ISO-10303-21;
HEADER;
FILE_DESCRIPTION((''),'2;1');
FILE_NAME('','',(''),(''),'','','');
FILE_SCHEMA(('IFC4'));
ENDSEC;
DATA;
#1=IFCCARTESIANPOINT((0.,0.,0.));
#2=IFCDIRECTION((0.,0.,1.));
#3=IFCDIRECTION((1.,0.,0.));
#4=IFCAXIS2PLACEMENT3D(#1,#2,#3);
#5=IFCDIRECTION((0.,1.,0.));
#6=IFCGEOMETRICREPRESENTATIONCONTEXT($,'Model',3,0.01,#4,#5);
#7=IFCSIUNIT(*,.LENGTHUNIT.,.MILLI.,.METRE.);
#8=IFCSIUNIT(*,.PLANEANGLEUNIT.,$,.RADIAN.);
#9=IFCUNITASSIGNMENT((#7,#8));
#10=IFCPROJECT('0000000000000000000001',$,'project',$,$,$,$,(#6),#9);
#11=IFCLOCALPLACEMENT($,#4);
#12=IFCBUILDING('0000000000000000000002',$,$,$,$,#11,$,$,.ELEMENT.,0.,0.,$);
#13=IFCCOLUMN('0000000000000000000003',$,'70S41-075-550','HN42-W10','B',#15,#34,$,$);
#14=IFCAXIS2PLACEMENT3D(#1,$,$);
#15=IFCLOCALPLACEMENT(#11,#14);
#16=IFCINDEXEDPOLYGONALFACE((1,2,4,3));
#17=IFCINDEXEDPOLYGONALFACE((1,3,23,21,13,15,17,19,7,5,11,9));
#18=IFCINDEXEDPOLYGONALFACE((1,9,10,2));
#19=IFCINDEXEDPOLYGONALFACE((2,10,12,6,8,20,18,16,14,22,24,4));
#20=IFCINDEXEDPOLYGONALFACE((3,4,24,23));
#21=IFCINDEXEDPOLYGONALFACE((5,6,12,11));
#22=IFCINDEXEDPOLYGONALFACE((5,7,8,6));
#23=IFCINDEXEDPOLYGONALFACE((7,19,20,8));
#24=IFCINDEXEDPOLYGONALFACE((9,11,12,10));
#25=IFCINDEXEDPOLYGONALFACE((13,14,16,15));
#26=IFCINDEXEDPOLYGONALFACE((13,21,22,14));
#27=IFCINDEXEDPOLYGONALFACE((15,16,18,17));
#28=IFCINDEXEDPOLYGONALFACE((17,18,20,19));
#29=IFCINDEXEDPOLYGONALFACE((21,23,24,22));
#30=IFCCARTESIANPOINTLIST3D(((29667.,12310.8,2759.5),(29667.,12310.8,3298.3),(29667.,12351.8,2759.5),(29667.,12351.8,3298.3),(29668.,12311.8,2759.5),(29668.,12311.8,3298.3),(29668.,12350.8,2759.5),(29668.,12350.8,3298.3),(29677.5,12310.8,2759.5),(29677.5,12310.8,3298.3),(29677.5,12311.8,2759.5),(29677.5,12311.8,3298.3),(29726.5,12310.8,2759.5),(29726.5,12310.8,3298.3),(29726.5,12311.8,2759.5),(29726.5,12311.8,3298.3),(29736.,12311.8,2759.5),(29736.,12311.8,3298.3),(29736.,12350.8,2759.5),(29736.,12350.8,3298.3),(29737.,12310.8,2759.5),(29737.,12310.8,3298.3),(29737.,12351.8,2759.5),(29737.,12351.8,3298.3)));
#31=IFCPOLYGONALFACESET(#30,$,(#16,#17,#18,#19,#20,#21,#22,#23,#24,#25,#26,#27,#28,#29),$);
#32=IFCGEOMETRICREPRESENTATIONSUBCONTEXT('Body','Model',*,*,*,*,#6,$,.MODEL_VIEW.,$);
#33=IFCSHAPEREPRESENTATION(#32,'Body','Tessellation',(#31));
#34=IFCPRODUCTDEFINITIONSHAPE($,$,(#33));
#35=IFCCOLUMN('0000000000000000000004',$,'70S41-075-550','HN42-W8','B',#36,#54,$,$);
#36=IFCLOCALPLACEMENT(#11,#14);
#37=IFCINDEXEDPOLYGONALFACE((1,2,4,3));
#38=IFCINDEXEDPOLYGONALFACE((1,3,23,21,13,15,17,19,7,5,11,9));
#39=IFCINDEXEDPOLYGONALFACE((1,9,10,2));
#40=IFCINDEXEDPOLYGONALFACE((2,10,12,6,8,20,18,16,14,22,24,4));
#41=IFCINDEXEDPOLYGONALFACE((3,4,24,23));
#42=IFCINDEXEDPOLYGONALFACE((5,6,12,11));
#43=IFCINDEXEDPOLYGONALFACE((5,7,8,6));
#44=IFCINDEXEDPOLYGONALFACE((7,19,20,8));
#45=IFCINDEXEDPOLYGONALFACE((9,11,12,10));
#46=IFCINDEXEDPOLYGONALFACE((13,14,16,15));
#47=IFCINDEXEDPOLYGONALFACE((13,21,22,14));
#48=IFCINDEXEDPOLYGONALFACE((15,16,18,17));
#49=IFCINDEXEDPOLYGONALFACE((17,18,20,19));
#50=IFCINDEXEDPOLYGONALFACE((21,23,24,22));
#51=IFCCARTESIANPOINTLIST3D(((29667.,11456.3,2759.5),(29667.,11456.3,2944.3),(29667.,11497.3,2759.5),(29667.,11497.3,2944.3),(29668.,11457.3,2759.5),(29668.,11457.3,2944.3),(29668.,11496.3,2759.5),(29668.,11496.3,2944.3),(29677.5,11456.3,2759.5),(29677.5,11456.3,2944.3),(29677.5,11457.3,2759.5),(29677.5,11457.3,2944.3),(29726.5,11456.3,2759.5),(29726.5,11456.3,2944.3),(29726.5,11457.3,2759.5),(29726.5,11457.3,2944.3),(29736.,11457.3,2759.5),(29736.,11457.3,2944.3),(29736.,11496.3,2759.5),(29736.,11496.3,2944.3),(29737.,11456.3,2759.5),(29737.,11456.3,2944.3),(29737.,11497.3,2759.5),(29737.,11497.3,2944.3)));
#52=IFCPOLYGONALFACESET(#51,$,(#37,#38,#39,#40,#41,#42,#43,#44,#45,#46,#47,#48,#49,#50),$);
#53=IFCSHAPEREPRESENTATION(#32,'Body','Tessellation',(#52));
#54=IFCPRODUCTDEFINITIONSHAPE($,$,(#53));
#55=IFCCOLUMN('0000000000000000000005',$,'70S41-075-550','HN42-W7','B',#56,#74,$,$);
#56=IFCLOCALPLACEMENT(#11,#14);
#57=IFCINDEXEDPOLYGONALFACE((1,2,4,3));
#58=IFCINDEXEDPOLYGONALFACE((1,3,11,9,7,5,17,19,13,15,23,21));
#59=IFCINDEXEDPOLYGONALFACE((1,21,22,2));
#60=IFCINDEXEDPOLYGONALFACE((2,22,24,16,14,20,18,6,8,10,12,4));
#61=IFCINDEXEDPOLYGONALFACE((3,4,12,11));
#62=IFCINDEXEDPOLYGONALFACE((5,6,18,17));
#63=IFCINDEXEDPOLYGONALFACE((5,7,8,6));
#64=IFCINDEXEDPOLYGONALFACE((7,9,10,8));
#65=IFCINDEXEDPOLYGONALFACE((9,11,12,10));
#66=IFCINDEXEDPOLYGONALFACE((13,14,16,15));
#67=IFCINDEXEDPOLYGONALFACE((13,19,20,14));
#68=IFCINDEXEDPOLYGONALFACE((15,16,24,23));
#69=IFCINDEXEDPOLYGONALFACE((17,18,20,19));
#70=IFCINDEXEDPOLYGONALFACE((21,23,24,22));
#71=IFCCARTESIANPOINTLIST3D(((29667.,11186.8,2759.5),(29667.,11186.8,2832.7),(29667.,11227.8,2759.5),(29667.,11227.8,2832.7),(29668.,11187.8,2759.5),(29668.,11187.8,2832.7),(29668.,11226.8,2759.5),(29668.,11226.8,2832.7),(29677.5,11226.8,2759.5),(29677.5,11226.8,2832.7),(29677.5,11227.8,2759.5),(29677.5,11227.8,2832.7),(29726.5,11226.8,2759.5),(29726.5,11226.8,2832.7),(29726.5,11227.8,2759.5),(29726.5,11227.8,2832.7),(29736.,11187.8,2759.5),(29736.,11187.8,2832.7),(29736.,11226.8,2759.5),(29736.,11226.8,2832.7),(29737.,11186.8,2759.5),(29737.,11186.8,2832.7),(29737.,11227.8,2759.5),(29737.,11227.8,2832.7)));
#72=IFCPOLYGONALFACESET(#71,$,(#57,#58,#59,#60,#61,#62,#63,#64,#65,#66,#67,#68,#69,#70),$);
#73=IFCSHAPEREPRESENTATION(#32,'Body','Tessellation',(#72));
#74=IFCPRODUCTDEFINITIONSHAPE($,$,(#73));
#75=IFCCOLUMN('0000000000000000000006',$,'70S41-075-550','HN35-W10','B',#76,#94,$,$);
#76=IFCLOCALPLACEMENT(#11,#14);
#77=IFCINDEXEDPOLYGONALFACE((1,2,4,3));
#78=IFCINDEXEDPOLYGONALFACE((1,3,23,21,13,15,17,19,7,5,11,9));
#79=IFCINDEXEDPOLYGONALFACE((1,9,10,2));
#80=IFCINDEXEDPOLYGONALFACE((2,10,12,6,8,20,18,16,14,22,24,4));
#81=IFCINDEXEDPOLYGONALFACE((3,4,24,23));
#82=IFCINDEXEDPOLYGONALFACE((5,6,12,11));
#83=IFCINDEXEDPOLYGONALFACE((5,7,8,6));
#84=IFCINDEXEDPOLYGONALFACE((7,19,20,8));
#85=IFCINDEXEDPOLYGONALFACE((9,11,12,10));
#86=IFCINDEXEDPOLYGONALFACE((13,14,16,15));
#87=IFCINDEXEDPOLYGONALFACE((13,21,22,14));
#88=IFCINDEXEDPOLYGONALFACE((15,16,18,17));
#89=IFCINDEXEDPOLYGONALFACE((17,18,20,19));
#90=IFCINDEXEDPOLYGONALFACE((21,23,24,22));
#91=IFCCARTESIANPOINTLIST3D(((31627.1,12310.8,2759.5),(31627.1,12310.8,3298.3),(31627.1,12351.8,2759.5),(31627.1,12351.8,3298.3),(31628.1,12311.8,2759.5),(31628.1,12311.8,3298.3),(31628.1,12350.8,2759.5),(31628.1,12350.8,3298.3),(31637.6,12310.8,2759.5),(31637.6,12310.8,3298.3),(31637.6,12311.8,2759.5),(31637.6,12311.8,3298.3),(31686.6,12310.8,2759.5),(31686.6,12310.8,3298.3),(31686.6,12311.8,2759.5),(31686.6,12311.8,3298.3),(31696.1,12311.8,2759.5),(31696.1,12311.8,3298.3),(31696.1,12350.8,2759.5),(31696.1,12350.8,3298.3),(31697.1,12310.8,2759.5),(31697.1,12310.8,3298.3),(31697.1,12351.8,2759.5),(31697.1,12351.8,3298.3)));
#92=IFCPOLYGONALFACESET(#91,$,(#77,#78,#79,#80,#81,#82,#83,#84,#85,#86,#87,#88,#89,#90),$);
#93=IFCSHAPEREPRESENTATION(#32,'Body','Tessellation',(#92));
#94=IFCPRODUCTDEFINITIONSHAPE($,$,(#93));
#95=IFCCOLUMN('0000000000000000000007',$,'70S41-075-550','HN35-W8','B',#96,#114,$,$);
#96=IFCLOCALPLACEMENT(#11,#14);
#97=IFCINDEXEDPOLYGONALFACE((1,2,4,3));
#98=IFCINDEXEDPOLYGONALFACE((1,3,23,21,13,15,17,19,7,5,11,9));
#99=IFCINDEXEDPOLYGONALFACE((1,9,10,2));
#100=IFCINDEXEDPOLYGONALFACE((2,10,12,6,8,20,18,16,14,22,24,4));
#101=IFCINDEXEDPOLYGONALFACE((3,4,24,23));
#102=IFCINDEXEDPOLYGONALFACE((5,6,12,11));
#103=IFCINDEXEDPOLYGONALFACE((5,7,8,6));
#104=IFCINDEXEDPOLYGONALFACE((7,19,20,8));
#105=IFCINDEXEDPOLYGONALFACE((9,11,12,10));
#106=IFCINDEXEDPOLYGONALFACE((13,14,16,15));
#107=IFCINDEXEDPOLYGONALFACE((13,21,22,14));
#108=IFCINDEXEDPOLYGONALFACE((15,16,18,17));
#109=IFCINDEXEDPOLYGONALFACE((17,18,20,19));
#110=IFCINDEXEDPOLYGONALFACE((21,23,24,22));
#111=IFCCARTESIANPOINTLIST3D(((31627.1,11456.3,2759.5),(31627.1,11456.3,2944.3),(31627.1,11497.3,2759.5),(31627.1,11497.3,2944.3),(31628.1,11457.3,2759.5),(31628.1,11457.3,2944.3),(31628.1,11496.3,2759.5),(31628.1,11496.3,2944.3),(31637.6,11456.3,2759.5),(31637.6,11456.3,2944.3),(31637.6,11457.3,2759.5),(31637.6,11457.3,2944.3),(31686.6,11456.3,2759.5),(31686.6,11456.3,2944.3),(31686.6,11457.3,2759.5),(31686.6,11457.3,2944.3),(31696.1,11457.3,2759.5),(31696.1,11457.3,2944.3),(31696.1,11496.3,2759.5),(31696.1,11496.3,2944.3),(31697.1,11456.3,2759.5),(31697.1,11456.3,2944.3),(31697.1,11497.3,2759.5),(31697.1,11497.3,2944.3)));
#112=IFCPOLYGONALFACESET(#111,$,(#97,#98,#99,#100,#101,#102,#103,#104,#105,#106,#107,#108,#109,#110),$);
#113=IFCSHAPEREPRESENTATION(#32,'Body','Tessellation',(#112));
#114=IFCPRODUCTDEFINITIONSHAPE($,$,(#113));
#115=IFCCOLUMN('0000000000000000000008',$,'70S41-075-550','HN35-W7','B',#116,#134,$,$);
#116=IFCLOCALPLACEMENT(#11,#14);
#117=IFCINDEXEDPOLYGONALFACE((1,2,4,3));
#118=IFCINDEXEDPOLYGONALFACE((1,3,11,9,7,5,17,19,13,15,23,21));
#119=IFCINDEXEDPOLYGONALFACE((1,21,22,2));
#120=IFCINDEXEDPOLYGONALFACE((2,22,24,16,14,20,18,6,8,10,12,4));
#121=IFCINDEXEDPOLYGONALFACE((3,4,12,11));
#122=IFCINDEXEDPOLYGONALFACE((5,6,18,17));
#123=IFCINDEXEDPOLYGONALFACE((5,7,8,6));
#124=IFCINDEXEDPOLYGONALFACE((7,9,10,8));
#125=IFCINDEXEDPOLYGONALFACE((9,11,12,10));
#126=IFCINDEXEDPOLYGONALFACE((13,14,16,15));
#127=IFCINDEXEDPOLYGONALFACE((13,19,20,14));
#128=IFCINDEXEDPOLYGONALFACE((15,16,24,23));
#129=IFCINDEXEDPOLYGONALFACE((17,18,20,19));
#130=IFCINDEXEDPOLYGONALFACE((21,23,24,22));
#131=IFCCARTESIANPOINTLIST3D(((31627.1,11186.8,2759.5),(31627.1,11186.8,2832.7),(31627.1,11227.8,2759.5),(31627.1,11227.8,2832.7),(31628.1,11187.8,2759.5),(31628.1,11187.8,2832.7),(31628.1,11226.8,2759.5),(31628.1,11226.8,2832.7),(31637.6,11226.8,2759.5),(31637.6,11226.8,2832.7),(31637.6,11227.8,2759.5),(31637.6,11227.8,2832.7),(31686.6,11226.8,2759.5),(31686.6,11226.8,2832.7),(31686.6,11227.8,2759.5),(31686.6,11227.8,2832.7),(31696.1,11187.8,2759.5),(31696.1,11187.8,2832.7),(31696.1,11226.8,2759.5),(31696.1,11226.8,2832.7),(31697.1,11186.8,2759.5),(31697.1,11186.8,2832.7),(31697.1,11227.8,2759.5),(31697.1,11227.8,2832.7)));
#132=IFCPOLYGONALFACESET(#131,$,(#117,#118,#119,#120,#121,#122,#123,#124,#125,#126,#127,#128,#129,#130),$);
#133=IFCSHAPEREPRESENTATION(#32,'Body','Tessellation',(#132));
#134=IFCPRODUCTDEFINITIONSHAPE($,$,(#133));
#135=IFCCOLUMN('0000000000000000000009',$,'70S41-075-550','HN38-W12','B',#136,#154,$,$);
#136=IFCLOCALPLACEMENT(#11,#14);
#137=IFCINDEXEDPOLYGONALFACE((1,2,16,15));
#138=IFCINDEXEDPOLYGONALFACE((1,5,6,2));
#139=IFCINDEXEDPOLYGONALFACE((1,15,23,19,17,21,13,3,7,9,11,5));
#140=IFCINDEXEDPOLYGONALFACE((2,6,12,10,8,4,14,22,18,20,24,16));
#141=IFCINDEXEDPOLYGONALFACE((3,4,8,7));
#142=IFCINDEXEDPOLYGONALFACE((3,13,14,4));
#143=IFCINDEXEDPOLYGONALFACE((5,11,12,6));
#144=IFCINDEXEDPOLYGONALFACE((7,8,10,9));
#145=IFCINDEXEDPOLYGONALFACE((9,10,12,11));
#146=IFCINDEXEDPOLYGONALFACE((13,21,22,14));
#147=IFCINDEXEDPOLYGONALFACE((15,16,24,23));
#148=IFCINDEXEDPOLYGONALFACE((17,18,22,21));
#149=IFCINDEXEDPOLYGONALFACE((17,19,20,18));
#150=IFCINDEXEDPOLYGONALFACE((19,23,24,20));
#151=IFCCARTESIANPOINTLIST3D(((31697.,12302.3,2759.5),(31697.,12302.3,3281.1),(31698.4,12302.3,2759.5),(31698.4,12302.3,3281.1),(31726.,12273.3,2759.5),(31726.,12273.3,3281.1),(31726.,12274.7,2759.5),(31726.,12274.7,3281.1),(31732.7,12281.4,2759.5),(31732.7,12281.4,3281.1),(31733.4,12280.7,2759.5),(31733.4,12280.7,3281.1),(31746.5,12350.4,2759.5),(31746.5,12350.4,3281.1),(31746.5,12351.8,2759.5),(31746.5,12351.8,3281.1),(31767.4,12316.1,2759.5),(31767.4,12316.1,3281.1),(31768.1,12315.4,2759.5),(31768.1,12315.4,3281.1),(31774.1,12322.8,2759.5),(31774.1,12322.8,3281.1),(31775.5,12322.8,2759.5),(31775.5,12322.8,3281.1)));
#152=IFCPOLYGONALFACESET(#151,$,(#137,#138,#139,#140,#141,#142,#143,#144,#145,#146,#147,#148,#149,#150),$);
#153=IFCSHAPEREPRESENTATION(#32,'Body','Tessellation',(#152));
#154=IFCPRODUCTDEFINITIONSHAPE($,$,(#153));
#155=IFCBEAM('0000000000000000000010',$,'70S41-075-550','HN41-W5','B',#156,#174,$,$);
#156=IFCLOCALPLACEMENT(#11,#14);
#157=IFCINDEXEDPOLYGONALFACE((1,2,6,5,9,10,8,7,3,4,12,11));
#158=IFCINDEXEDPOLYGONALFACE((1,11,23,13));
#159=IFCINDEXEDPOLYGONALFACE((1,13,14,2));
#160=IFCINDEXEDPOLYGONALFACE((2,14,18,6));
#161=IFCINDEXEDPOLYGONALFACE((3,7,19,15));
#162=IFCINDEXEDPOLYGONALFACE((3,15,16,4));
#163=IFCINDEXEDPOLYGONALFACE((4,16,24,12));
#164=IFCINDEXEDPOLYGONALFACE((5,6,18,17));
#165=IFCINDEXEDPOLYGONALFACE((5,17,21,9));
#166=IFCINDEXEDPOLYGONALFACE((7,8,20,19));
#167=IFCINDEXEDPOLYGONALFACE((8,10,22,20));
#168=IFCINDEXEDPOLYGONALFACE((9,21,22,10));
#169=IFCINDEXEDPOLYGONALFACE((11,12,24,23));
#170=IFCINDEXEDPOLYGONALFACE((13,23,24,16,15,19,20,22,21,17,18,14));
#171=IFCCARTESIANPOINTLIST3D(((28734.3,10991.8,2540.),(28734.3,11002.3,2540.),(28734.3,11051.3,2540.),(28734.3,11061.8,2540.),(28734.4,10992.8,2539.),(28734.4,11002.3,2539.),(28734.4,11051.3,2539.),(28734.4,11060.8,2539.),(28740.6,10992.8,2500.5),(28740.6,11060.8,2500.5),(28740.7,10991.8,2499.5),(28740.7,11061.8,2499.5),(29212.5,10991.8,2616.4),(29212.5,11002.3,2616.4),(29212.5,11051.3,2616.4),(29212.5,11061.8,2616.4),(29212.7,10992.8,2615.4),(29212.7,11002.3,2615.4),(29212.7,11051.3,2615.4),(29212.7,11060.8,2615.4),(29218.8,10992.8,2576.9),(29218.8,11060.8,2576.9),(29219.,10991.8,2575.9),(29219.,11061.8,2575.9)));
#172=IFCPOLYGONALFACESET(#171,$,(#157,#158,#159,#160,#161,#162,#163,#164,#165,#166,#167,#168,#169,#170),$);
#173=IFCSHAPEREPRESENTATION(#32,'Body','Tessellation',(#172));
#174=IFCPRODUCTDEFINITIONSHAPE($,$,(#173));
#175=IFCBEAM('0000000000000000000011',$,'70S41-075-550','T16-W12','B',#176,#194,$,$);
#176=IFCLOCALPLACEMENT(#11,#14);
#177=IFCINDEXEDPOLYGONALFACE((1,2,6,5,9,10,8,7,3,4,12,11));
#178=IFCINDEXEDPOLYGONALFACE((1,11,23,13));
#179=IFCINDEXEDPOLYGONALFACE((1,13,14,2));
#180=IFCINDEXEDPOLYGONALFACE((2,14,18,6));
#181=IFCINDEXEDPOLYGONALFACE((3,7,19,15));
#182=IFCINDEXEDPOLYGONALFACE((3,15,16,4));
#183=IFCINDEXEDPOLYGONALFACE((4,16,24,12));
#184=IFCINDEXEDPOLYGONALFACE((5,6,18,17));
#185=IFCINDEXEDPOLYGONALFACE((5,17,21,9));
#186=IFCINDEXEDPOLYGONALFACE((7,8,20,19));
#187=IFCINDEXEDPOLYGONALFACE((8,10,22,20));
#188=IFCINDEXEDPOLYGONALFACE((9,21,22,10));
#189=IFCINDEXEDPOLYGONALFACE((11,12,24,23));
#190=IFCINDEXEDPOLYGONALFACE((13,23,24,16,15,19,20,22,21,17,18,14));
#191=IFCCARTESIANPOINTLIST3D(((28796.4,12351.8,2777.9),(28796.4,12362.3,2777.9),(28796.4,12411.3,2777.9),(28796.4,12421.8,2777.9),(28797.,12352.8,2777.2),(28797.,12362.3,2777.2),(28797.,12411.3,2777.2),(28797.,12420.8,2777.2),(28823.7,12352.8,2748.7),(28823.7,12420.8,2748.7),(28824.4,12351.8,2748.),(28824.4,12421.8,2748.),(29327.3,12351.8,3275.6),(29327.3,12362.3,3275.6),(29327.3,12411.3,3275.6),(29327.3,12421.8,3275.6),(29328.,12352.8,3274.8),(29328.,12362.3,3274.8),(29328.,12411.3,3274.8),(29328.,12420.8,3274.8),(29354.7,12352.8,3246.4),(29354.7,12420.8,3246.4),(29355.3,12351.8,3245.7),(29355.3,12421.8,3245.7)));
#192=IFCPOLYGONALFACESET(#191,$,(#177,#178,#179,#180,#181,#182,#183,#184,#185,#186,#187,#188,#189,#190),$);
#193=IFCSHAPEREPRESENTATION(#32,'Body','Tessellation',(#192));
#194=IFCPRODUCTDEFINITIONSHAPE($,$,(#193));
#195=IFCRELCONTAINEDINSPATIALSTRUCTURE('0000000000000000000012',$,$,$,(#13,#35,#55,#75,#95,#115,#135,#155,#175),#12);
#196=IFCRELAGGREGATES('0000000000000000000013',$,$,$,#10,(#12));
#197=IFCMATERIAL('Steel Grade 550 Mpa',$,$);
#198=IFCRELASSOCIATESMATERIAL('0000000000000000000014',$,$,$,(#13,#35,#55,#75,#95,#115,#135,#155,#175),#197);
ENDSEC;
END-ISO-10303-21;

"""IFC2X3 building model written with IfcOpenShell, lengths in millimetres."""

from ifc_helpers import new_model, si_unit, direction, frame, origin, origin_with_axes, origin_2d_with_axis, place, context, subcontext, project, spatial, c_section, extrude, source, transform, mapped, material, element, save


model = new_model("IFC2X3")

# Units and contexts
model_context = context("Model", 3, precision=0.01, world=origin_with_axes(), true_north=direction((0.0, 1.0, 0.0)))
body_context = subcontext(model_context, "Body", "Model", "MODEL_VIEW")
ifc_project = project(units=[si_unit("LENGTHUNIT", "METRE", prefix="MILLI"), si_unit("PLANEANGLEUNIT", "RADIAN")], contexts=[model_context])

# Building
building_placement = place(None, origin_with_axes())
building = spatial("IfcBuilding", under=ifc_project, at=building_placement, CompositionType="ELEMENT", ElevationOfRefHeight=0.0, ElevationOfTerrain=0.0)

# Columns
ifc_material = material(Name="Steel Grade 550 Mpa")
shared_shape_1 = source(origin(), body_context, "Body", "SweptSolid", [
    extrude(c_section(Depth=70.0, Width=41.0, WallThickness=1.0, Girth=10.5, at=origin_2d_with_axis()), origin_with_axes(), (0.0, 0.0, 1.0), 538.8),
])
column_1_placement = place(None, frame((29702.0, 12331.3, 2759.5), z_axis=(0.0, 0.0, 1.0), x_axis=(0.0, -1.0, 0.0)))
element("IfcColumn", 1, at=column_1_placement, inside=building, material=ifc_material, Name="70S41-075-550", Description="HN42-W10", ObjectType="B", context=body_context, shape_type="MappedRepresentation", body=[
    mapped(shared_shape_1, transform((0.0, 0.0, 0.0), scale=1.0)),
])
shared_shape_2 = source(origin(), body_context, "Body", "SweptSolid", [
    extrude(c_section(Depth=70.0, Width=41.0, WallThickness=1.0, Girth=10.5, at=origin_2d_with_axis()), origin_with_axes(), (0.0, 0.0, 1.0), 184.8),
])
column_2_placement = place(None, frame((29702.0, 11476.8, 2759.5), z_axis=(0.0, 0.0, 1.0), x_axis=(0.0, -1.0, 0.0)))
element("IfcColumn", 2, at=column_2_placement, inside=building, material=ifc_material, Name="70S41-075-550", Description="HN42-W8", ObjectType="B", context=body_context, shape_type="MappedRepresentation", body=[
    mapped(shared_shape_2, transform((0.0, 0.0, 0.0), scale=1.0)),
])
shared_shape_3 = source(origin(), body_context, "Body", "SweptSolid", [
    extrude(c_section(Depth=70.0, Width=41.0, WallThickness=1.0, Girth=10.5, at=origin_2d_with_axis()), origin_with_axes(), (0.0, 0.0, 1.0), 73.2),
])
column_3_placement = place(None, frame((29702.0, 11207.3, 2832.7), z_axis=(0.0, 0.0, -1.0), x_axis=(0.0, 1.0, 0.0)))
element("IfcColumn", 3, at=column_3_placement, inside=building, material=ifc_material, Name="70S41-075-550", Description="HN42-W7", ObjectType="B", context=body_context, shape_type="MappedRepresentation", body=[
    mapped(shared_shape_3, transform((0.0, 0.0, 0.0), scale=1.0)),
])
shared_shape_4 = source(origin(), body_context, "Body", "SweptSolid", [
    extrude(c_section(Depth=70.0, Width=41.0, WallThickness=1.0, Girth=10.5, at=origin_2d_with_axis()), origin_with_axes(), (0.0, 0.0, 1.0), 538.8),
])
column_4_placement = place(None, frame((31662.1, 12331.3, 2759.5), z_axis=(0.0, 0.0, 1.0), x_axis=(0.0, -1.0, 0.0)))
element("IfcColumn", 4, at=column_4_placement, inside=building, material=ifc_material, Name="70S41-075-550", Description="HN35-W10", ObjectType="B", context=body_context, shape_type="MappedRepresentation", body=[
    mapped(shared_shape_4, transform((0.0, 0.0, 0.0), scale=1.0)),
])
shared_shape_5 = source(origin(), body_context, "Body", "SweptSolid", [
    extrude(c_section(Depth=70.0, Width=41.0, WallThickness=1.0, Girth=10.5, at=origin_2d_with_axis()), origin_with_axes(), (0.0, 0.0, 1.0), 184.8),
])
column_5_placement = place(None, frame((31662.1, 11476.8, 2759.5), z_axis=(0.0, 0.0, 1.0), x_axis=(0.0, -1.0, 0.0)))
element("IfcColumn", 5, at=column_5_placement, inside=building, material=ifc_material, Name="70S41-075-550", Description="HN35-W8", ObjectType="B", context=body_context, shape_type="MappedRepresentation", body=[
    mapped(shared_shape_5, transform((0.0, 0.0, 0.0), scale=1.0)),
])
shared_shape_6 = source(origin(), body_context, "Body", "SweptSolid", [
    extrude(c_section(Depth=70.0, Width=41.0, WallThickness=1.0, Girth=10.5, at=origin_2d_with_axis()), origin_with_axes(), (0.0, 0.0, 1.0), 73.2),
])
column_6_placement = place(None, frame((31662.1, 11207.3, 2832.7), z_axis=(0.0, 0.0, -1.0), x_axis=(0.0, 1.0, 0.0)))
element("IfcColumn", 6, at=column_6_placement, inside=building, material=ifc_material, Name="70S41-075-550", Description="HN35-W7", ObjectType="B", context=body_context, shape_type="MappedRepresentation", body=[
    mapped(shared_shape_6, transform((0.0, 0.0, 0.0), scale=1.0)),
])
shared_shape_7 = source(origin(), body_context, "Body", "SweptSolid", [
    extrude(c_section(Depth=70.0, Width=41.0, WallThickness=1.0, Girth=10.5, at=origin_2d_with_axis()), origin_with_axes(), (0.0, 0.0, 1.0), 521.6),
])
column_7_placement = place(None, frame((31736.3, 12312.5, 2759.5), z_axis=(0.0, 0.0, 1.0), x_axis=(0.707107, -0.707107, 0.0)))
element("IfcColumn", 7, at=column_7_placement, inside=building, material=ifc_material, Name="70S41-075-550", Description="HN38-W12", ObjectType="B", context=body_context, shape_type="MappedRepresentation", body=[
    mapped(shared_shape_7, transform((0.0, 0.0, 0.0), scale=1.0)),
])

# Beams
shared_shape_8 = source(origin(), body_context, "Body", "SweptSolid", [
    extrude(c_section(Depth=70.0, Width=41.0, WallThickness=1.0, Girth=10.5, at=origin_2d_with_axis()), origin_with_axes(), (0.0, 0.0, 1.0), 484.3),
])
beam_1_placement = place(None, frame((29215.7, 11026.8, 2596.1), z_axis=(-0.987487, 0.0, -0.157701), x_axis=(-0.157701, 0.0, 0.987487)))
element("IfcBeam", 8, at=beam_1_placement, inside=building, material=ifc_material, Name="70S41-075-550", Description="HN41-W5", ObjectType="B", context=body_context, shape_type="MappedRepresentation", body=[
    mapped(shared_shape_8, transform((0.0, 0.0, 0.0), scale=1.0)),
])
shared_shape_9 = source(origin(), body_context, "Body", "SweptSolid", [
    extrude(c_section(Depth=70.0, Width=41.0, WallThickness=1.0, Girth=10.5, at=origin_2d_with_axis()), origin_with_axes(), (0.0, 0.0, 1.0), 727.7),
])
beam_2_placement = place(None, frame((29341.3, 12386.8, 3260.6), z_axis=(-0.72962, 0.0, -0.683853), x_axis=(-0.683853, 0.0, 0.72962)))
element("IfcBeam", 9, at=beam_2_placement, inside=building, material=ifc_material, Name="70S41-075-550", Description="T16-W12", ObjectType="B", context=body_context, shape_type="MappedRepresentation", body=[
    mapped(shared_shape_9, transform((0.0, 0.0, 0.0), scale=1.0)),
])

save(model, "model.ifc")
